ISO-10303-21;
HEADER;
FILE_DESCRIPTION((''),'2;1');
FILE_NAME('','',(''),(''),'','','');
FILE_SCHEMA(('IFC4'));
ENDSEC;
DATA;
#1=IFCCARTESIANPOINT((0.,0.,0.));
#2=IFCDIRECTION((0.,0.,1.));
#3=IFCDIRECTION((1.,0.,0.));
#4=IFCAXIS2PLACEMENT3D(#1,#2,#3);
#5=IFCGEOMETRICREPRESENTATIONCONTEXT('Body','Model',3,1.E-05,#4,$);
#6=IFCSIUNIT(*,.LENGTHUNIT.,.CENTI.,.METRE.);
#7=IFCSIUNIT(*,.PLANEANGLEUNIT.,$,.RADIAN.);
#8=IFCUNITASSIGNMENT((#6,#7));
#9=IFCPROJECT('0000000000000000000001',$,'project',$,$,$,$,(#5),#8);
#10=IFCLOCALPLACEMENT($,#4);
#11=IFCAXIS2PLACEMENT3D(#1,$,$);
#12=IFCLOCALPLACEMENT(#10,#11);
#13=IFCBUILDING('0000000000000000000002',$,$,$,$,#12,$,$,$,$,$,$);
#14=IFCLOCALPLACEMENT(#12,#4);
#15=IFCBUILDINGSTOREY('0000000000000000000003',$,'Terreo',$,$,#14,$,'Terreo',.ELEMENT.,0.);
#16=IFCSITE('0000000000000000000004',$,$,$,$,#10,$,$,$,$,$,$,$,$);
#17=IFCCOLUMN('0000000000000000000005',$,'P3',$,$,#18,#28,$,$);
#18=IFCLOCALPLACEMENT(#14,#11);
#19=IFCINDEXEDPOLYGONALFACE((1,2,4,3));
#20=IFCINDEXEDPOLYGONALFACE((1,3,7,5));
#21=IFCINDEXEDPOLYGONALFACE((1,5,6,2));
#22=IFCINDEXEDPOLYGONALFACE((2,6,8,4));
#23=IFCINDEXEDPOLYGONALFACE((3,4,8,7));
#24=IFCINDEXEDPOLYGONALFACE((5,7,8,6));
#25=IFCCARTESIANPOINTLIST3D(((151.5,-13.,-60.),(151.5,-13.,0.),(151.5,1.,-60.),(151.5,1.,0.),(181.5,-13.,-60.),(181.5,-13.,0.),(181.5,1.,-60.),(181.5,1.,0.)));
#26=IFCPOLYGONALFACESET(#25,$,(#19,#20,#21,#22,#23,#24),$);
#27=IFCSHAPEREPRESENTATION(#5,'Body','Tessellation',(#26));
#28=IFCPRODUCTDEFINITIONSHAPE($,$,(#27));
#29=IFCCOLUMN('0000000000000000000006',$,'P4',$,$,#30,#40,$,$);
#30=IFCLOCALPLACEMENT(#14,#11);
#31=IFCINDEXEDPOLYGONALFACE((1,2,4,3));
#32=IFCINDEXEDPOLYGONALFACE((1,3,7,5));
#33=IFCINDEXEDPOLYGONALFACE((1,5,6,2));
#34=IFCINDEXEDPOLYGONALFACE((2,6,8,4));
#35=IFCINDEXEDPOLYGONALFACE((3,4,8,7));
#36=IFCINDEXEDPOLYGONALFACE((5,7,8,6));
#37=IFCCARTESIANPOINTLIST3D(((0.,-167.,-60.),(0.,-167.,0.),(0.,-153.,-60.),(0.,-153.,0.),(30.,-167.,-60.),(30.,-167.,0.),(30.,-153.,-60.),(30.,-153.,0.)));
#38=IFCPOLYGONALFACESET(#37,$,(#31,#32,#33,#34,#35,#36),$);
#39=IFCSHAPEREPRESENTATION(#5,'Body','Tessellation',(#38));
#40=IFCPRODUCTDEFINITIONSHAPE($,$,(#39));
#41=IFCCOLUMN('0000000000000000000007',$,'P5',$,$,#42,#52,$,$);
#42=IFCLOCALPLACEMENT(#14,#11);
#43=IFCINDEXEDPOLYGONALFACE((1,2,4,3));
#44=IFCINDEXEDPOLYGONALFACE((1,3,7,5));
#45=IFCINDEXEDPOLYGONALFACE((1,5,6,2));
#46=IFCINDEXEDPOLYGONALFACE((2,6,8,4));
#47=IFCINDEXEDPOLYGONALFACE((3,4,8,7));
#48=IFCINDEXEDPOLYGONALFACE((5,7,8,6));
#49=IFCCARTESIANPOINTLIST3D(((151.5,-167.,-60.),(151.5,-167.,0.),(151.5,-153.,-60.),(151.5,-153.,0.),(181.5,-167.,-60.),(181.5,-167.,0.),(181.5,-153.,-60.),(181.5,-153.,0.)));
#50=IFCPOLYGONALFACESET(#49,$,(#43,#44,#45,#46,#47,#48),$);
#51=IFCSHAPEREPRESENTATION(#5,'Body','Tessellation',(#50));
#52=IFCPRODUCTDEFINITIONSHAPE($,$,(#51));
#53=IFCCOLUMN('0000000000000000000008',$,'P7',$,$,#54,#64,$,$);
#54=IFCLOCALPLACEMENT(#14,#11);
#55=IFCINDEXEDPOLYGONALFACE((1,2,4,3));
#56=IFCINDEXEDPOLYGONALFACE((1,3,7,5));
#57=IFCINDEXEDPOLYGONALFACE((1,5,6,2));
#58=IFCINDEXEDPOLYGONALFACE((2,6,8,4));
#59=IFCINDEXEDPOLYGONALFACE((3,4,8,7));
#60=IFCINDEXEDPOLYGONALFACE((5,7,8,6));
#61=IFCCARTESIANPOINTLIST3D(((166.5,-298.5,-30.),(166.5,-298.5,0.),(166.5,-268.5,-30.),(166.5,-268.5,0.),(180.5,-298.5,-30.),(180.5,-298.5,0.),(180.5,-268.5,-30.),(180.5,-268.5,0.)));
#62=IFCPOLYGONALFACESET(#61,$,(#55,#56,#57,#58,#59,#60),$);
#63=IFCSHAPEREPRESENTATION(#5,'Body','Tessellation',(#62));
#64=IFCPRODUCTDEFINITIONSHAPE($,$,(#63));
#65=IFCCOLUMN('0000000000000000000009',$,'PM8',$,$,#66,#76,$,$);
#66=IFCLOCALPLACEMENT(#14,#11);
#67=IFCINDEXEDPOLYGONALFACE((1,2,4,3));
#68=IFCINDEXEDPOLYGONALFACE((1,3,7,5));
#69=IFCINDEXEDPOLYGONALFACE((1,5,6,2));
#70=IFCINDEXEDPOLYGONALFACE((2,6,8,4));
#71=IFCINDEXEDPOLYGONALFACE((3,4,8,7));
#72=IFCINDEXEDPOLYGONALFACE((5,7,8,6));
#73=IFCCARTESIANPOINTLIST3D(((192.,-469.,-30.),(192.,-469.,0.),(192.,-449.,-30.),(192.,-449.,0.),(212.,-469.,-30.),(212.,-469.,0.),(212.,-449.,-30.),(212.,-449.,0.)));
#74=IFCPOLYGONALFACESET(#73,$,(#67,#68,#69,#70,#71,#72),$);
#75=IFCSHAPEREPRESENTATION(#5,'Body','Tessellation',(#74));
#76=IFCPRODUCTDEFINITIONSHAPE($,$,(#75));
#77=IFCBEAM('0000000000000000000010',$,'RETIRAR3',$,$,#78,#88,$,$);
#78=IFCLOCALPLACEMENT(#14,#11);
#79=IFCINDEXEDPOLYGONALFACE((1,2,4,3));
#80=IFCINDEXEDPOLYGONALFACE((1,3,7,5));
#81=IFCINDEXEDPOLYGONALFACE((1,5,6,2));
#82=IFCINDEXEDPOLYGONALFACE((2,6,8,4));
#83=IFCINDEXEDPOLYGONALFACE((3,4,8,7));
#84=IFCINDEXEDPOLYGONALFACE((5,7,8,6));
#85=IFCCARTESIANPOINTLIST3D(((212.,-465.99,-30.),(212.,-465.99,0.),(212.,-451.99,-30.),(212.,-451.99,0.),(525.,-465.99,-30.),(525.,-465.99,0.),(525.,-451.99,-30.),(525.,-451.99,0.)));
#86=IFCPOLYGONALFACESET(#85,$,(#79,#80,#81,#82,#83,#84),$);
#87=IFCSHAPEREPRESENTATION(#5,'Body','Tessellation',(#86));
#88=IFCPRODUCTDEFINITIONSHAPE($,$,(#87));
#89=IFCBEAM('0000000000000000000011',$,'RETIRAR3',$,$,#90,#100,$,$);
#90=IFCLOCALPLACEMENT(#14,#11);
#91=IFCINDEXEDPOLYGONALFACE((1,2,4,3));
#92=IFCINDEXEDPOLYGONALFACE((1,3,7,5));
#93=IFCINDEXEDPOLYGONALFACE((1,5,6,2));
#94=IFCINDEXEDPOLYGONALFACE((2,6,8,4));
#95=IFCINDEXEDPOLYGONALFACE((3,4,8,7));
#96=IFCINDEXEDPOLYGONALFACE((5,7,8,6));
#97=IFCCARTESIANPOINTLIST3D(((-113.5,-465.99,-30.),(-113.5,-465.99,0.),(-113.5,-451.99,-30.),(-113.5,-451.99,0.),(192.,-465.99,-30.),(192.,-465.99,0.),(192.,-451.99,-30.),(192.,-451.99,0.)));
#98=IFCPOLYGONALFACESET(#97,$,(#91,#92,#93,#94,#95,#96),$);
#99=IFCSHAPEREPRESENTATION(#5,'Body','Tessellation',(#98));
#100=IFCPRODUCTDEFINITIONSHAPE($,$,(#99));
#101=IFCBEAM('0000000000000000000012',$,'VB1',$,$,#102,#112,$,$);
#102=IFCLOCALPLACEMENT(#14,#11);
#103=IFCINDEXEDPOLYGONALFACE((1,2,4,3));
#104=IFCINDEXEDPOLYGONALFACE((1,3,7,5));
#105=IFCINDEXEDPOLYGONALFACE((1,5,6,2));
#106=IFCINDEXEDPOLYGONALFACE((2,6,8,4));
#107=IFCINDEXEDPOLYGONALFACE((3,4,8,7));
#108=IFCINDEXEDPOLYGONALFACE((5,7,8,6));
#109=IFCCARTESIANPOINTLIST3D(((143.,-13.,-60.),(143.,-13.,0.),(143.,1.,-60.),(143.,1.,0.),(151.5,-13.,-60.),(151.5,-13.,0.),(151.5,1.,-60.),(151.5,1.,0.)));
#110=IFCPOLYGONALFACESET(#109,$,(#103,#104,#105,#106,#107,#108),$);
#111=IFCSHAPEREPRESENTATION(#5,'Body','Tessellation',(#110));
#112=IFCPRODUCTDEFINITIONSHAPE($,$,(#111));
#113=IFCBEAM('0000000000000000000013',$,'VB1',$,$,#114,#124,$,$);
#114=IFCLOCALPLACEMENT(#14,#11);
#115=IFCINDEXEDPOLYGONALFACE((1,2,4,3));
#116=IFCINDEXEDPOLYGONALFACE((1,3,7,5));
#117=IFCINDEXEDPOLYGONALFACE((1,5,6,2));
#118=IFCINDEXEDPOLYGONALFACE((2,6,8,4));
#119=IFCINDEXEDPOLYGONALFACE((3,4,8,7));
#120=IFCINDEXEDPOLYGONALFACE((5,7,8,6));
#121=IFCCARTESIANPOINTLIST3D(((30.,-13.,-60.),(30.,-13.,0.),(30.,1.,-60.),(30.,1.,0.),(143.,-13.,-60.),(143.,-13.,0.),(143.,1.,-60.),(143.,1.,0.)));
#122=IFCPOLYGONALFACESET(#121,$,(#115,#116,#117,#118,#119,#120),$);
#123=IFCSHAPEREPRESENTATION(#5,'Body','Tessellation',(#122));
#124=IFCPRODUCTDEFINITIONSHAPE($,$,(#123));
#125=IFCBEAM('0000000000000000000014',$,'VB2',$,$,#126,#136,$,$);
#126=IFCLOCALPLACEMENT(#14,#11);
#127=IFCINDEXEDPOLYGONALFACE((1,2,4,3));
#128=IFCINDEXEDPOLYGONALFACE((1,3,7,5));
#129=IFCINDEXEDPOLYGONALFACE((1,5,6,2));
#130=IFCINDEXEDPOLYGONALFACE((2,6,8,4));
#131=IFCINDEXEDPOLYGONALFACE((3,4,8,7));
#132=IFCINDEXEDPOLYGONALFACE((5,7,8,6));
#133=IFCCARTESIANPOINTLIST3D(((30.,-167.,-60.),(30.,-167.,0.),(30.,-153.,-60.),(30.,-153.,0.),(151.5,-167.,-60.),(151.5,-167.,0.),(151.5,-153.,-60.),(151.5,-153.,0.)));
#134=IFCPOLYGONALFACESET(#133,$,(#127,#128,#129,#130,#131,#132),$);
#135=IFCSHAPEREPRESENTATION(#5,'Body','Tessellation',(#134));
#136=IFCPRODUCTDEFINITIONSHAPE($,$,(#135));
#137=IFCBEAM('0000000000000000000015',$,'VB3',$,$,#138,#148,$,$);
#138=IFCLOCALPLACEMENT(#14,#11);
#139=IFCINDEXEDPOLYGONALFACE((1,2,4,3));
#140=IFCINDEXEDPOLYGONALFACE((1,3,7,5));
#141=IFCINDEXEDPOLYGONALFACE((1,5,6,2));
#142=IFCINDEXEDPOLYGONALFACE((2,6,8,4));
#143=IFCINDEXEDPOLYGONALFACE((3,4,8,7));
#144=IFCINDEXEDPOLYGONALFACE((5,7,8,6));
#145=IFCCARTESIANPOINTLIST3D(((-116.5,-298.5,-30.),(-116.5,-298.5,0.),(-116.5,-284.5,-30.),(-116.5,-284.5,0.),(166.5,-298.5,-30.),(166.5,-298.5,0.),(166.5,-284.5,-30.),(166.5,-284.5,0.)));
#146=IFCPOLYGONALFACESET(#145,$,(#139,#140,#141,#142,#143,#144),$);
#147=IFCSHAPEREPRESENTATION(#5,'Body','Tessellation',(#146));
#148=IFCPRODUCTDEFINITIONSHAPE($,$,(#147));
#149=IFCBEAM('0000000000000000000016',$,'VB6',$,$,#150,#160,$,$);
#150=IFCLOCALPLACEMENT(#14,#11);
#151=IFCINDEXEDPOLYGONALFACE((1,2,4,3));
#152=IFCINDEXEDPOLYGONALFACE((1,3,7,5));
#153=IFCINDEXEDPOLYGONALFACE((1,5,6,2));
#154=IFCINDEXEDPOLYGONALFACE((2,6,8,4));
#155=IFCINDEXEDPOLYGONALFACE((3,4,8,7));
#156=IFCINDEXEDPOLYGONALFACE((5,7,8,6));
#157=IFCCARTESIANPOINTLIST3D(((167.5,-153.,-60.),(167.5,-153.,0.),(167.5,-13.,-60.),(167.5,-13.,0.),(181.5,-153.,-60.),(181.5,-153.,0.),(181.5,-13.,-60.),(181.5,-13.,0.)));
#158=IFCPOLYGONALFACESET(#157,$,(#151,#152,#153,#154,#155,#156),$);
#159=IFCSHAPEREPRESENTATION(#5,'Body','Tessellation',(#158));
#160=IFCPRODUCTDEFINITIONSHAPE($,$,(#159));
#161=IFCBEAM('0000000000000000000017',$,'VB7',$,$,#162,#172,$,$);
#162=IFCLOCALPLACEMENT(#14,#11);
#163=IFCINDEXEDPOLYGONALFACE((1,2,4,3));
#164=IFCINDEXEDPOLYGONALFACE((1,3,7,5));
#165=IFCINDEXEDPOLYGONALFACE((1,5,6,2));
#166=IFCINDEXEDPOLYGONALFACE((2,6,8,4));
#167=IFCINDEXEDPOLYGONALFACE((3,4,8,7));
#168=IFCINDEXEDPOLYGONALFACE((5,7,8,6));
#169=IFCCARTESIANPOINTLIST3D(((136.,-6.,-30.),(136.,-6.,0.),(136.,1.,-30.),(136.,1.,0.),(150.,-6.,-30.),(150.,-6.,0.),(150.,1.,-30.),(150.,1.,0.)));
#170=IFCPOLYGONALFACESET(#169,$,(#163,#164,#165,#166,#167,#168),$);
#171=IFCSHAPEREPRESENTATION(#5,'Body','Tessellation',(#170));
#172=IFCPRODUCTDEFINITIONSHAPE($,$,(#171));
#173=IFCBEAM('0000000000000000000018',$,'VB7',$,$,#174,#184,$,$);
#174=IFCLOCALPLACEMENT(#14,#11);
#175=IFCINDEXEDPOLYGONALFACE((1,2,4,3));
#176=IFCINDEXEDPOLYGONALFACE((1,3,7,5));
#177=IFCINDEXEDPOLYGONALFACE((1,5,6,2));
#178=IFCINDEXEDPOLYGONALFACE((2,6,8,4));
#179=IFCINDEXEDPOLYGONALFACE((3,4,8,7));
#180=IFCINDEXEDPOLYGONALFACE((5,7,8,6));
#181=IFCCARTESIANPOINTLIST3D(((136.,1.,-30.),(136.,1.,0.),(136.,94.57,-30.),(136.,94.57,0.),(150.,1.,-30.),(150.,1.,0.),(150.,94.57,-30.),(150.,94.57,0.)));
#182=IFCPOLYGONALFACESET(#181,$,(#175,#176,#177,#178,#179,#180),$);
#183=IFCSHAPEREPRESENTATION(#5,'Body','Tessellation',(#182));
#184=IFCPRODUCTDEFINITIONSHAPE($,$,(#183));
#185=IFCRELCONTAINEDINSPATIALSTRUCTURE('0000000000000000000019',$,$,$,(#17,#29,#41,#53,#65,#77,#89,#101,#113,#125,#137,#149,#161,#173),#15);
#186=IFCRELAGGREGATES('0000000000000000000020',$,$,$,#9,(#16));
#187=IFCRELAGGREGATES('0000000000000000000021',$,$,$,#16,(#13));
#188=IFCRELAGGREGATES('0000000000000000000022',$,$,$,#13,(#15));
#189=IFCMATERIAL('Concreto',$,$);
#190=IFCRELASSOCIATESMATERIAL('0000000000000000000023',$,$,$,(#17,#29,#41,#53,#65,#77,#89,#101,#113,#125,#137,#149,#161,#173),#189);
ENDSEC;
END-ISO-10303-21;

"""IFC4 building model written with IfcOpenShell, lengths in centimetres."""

from ifc_helpers import new_model, si_unit, frame, origin, origin_with_axes, origin_2d_with_axis, place, context, project, spatial, rectangle, extrude, material, element, save


model = new_model("IFC4")

# Units and contexts
model_context = context("Model", 3, precision=1e-05, world=origin_with_axes(), identifier="Body")
ifc_project = project(units=[si_unit("LENGTHUNIT", "METRE", prefix="CENTI"), si_unit("PLANEANGLEUNIT", "RADIAN")], contexts=[model_context])

# Site, building, storey
site_placement = place(None, origin_with_axes())
site = spatial("IfcSite", under=ifc_project, at=site_placement)
building_placement = place(site_placement, origin())
building = spatial("IfcBuilding", under=site, at=building_placement)
storey_placement = place(building_placement, origin_with_axes())
storey = spatial("IfcBuildingStorey", under=building, at=storey_placement, Name="Terreo", LongName="Terreo", CompositionType="ELEMENT", Elevation=0.0)

# Shared definitions
ifc_material = material(Name="Concreto")

# Columns
for number, where, z_axis, x_axis, name in (
    (1, (166.5, -6.0, 0.0), (0.0, 0.0, 1.0), (1.0, 0.0, 0.0), "P3"),
    (2, (15.0, -160.0, 0.0), (0.0, 0.0, 1.0), (1.0, 0.0, 0.0), "P4"),
    (3, (166.5, -160.0, 0.0), (0.0, 0.0, 1.0), (1.0, 0.0, 0.0), "P5"),
):
    element("IfcColumn", number, at=place(storey_placement, frame(where, z_axis=z_axis, x_axis=x_axis)), inside=storey, material=ifc_material, Name=name, context=model_context, shape_type="SolidModel", body=[
        extrude(rectangle(XDim=14.0, YDim=30.0, at=origin_2d_with_axis()), frame((0.0, 0.0, -60.0), z_axis=(0.0, 0.0, 1.0), x_axis=(0.0, 1.0, 0.0)), (0.0, 0.0, 1.0), 60.0),
    ])
column_1_placement = place(storey_placement, frame((173.5, -283.5, 0.0), z_axis=(0.0, 0.0, 1.0), x_axis=(1.0, 0.0, 0.0)))
element("IfcColumn", 4, at=column_1_placement, inside=storey, material=ifc_material, Name="P7", context=model_context, shape_type="SolidModel", body=[
    extrude(rectangle(XDim=14.0, YDim=30.0, at=origin_2d_with_axis()), frame((0.0, 0.0, -30.0), z_axis=(0.0, 0.0, 1.0), x_axis=(1.0, 0.0, 0.0)), (0.0, 0.0, 1.0), 30.0),
])
column_2_placement = place(storey_placement, frame((202.0, -459.0, 0.0), z_axis=(0.0, 0.0, 1.0), x_axis=(1.0, 0.0, 0.0)))
element("IfcColumn", 5, at=column_2_placement, inside=storey, material=ifc_material, Name="PM8", context=model_context, shape_type="SolidModel", body=[
    extrude(rectangle(XDim=20.0, YDim=20.0, at=origin_2d_with_axis()), frame((0.0, 0.0, -30.0), z_axis=(0.0, 0.0, 1.0), x_axis=(1.0, 0.0, 0.0)), (0.0, 0.0, 1.0), 30.0),
])

# Beams
beam_1_placement = place(storey_placement, frame((368.5, -458.99, 0.0), z_axis=(0.0, 0.0, 1.0), x_axis=(1.0, 0.0, 0.0)))
element("IfcBeam", 6, at=beam_1_placement, inside=storey, material=ifc_material, Name="RETIRAR3", context=model_context, shape_type="SolidModel", body=[
    extrude(rectangle(XDim=14.0, YDim=30.0, at=origin_2d_with_axis()), frame((-156.5, 0.0, -15.0), z_axis=(1.0, 0.0, 0.0), x_axis=(0.0, -1.0, 0.0)), (0.0, 0.0, 1.0), 313.0),
])
beam_2_placement = place(storey_placement, frame((39.25, -458.99, 0.0), z_axis=(0.0, 0.0, 1.0), x_axis=(1.0, 0.0, 0.0)))
element("IfcBeam", 7, at=beam_2_placement, inside=storey, material=ifc_material, Name="RETIRAR3", context=model_context, shape_type="SolidModel", body=[
    extrude(rectangle(XDim=14.0, YDim=30.0, at=origin_2d_with_axis()), frame((-152.75, 0.0, -15.0), z_axis=(1.0, 0.0, 0.0), x_axis=(0.0, -1.0, 0.0)), (0.0, 0.0, 1.0), 305.5),
])
beam_3_placement = place(storey_placement, frame((147.25, -6.0, 0.0), z_axis=(0.0, 0.0, 1.0), x_axis=(1.0, 0.0, 0.0)))
element("IfcBeam", 8, at=beam_3_placement, inside=storey, material=ifc_material, Name="VB1", context=model_context, shape_type="SolidModel", body=[
    extrude(rectangle(XDim=14.0, YDim=60.0, at=origin_2d_with_axis()), frame((-4.25, 0.0, -30.0), z_axis=(1.0, 0.0, 0.0), x_axis=(0.0, 1.0, 0.0)), (0.0, 0.0, 1.0), 8.5),
])
beam_4_placement = place(storey_placement, frame((86.5, -6.0, 0.0), z_axis=(0.0, 0.0, 1.0), x_axis=(1.0, 0.0, 0.0)))
element("IfcBeam", 9, at=beam_4_placement, inside=storey, material=ifc_material, Name="VB1", context=model_context, shape_type="SolidModel", body=[
    extrude(rectangle(XDim=14.0, YDim=60.0, at=origin_2d_with_axis()), frame((-56.5, 0.0, -30.0), z_axis=(1.0, 0.0, 0.0), x_axis=(0.0, 1.0, 0.0)), (0.0, 0.0, 1.0), 113.0),
])
beam_5_placement = place(storey_placement, frame((90.75, -160.0, 0.0), z_axis=(0.0, 0.0, 1.0), x_axis=(1.0, 0.0, 0.0)))
element("IfcBeam", 10, at=beam_5_placement, inside=storey, material=ifc_material, Name="VB2", context=model_context, shape_type="SolidModel", body=[
    extrude(rectangle(XDim=14.0, YDim=60.0, at=origin_2d_with_axis()), frame((-60.75, 0.0, -30.0), z_axis=(1.0, 0.0, 0.0), x_axis=(0.0, -1.0, 0.0)), (0.0, 0.0, 1.0), 121.5),
])
beam_6_placement = place(storey_placement, frame((25.0, -291.5, 0.0), z_axis=(0.0, 0.0, 1.0), x_axis=(1.0, 0.0, 0.0)))
element("IfcBeam", 11, at=beam_6_placement, inside=storey, material=ifc_material, Name="VB3", context=model_context, shape_type="SolidModel", body=[
    extrude(rectangle(XDim=14.0, YDim=30.0, at=origin_2d_with_axis()), frame((-141.5, 0.0, -15.0), z_axis=(1.0, 0.0, 0.0), x_axis=(0.0, -1.0, 0.0)), (0.0, 0.0, 1.0), 283.0),
])
beam_7_placement = place(storey_placement, frame((174.5, -83.0, 0.0), z_axis=(0.0, 0.0, 1.0), x_axis=(1.0, 0.0, 0.0)))
element("IfcBeam", 12, at=beam_7_placement, inside=storey, material=ifc_material, Name="VB6", context=model_context, shape_type="SolidModel", body=[
    extrude(rectangle(XDim=14.0, YDim=60.0, at=origin_2d_with_axis()), frame((0.0, -70.0, -30.0), z_axis=(0.0, 1.0, 0.0), x_axis=(1.0, 0.0, 0.0)), (0.0, 0.0, 1.0), 140.0),
])
beam_8_placement = place(storey_placement, frame((143.0, -2.5, 0.0), z_axis=(0.0, 0.0, 1.0), x_axis=(1.0, 0.0, 0.0)))
element("IfcBeam", 13, at=beam_8_placement, inside=storey, material=ifc_material, Name="VB7", context=model_context, shape_type="SolidModel", body=[
    extrude(rectangle(XDim=14.0, YDim=30.0, at=origin_2d_with_axis()), frame((0.0, -3.5, -15.0), z_axis=(0.0, 1.0, 0.0), x_axis=(1.0, 0.0, 0.0)), (0.0, 0.0, 1.0), 7.0),
])
beam_9_placement = place(storey_placement, frame((143.0, 47.79, 0.0), z_axis=(0.0, 0.0, 1.0), x_axis=(1.0, 0.0, 0.0)))
element("IfcBeam", 14, at=beam_9_placement, inside=storey, material=ifc_material, Name="VB7", context=model_context, shape_type="SolidModel", body=[
    extrude(rectangle(XDim=14.0, YDim=30.0, at=origin_2d_with_axis()), frame((0.0, -46.79, -15.0), z_axis=(0.0, 1.0, 0.0), x_axis=(1.0, 0.0, 0.0)), (0.0, 0.0, 1.0), 93.57),
])

save(model, "model.ifc")
